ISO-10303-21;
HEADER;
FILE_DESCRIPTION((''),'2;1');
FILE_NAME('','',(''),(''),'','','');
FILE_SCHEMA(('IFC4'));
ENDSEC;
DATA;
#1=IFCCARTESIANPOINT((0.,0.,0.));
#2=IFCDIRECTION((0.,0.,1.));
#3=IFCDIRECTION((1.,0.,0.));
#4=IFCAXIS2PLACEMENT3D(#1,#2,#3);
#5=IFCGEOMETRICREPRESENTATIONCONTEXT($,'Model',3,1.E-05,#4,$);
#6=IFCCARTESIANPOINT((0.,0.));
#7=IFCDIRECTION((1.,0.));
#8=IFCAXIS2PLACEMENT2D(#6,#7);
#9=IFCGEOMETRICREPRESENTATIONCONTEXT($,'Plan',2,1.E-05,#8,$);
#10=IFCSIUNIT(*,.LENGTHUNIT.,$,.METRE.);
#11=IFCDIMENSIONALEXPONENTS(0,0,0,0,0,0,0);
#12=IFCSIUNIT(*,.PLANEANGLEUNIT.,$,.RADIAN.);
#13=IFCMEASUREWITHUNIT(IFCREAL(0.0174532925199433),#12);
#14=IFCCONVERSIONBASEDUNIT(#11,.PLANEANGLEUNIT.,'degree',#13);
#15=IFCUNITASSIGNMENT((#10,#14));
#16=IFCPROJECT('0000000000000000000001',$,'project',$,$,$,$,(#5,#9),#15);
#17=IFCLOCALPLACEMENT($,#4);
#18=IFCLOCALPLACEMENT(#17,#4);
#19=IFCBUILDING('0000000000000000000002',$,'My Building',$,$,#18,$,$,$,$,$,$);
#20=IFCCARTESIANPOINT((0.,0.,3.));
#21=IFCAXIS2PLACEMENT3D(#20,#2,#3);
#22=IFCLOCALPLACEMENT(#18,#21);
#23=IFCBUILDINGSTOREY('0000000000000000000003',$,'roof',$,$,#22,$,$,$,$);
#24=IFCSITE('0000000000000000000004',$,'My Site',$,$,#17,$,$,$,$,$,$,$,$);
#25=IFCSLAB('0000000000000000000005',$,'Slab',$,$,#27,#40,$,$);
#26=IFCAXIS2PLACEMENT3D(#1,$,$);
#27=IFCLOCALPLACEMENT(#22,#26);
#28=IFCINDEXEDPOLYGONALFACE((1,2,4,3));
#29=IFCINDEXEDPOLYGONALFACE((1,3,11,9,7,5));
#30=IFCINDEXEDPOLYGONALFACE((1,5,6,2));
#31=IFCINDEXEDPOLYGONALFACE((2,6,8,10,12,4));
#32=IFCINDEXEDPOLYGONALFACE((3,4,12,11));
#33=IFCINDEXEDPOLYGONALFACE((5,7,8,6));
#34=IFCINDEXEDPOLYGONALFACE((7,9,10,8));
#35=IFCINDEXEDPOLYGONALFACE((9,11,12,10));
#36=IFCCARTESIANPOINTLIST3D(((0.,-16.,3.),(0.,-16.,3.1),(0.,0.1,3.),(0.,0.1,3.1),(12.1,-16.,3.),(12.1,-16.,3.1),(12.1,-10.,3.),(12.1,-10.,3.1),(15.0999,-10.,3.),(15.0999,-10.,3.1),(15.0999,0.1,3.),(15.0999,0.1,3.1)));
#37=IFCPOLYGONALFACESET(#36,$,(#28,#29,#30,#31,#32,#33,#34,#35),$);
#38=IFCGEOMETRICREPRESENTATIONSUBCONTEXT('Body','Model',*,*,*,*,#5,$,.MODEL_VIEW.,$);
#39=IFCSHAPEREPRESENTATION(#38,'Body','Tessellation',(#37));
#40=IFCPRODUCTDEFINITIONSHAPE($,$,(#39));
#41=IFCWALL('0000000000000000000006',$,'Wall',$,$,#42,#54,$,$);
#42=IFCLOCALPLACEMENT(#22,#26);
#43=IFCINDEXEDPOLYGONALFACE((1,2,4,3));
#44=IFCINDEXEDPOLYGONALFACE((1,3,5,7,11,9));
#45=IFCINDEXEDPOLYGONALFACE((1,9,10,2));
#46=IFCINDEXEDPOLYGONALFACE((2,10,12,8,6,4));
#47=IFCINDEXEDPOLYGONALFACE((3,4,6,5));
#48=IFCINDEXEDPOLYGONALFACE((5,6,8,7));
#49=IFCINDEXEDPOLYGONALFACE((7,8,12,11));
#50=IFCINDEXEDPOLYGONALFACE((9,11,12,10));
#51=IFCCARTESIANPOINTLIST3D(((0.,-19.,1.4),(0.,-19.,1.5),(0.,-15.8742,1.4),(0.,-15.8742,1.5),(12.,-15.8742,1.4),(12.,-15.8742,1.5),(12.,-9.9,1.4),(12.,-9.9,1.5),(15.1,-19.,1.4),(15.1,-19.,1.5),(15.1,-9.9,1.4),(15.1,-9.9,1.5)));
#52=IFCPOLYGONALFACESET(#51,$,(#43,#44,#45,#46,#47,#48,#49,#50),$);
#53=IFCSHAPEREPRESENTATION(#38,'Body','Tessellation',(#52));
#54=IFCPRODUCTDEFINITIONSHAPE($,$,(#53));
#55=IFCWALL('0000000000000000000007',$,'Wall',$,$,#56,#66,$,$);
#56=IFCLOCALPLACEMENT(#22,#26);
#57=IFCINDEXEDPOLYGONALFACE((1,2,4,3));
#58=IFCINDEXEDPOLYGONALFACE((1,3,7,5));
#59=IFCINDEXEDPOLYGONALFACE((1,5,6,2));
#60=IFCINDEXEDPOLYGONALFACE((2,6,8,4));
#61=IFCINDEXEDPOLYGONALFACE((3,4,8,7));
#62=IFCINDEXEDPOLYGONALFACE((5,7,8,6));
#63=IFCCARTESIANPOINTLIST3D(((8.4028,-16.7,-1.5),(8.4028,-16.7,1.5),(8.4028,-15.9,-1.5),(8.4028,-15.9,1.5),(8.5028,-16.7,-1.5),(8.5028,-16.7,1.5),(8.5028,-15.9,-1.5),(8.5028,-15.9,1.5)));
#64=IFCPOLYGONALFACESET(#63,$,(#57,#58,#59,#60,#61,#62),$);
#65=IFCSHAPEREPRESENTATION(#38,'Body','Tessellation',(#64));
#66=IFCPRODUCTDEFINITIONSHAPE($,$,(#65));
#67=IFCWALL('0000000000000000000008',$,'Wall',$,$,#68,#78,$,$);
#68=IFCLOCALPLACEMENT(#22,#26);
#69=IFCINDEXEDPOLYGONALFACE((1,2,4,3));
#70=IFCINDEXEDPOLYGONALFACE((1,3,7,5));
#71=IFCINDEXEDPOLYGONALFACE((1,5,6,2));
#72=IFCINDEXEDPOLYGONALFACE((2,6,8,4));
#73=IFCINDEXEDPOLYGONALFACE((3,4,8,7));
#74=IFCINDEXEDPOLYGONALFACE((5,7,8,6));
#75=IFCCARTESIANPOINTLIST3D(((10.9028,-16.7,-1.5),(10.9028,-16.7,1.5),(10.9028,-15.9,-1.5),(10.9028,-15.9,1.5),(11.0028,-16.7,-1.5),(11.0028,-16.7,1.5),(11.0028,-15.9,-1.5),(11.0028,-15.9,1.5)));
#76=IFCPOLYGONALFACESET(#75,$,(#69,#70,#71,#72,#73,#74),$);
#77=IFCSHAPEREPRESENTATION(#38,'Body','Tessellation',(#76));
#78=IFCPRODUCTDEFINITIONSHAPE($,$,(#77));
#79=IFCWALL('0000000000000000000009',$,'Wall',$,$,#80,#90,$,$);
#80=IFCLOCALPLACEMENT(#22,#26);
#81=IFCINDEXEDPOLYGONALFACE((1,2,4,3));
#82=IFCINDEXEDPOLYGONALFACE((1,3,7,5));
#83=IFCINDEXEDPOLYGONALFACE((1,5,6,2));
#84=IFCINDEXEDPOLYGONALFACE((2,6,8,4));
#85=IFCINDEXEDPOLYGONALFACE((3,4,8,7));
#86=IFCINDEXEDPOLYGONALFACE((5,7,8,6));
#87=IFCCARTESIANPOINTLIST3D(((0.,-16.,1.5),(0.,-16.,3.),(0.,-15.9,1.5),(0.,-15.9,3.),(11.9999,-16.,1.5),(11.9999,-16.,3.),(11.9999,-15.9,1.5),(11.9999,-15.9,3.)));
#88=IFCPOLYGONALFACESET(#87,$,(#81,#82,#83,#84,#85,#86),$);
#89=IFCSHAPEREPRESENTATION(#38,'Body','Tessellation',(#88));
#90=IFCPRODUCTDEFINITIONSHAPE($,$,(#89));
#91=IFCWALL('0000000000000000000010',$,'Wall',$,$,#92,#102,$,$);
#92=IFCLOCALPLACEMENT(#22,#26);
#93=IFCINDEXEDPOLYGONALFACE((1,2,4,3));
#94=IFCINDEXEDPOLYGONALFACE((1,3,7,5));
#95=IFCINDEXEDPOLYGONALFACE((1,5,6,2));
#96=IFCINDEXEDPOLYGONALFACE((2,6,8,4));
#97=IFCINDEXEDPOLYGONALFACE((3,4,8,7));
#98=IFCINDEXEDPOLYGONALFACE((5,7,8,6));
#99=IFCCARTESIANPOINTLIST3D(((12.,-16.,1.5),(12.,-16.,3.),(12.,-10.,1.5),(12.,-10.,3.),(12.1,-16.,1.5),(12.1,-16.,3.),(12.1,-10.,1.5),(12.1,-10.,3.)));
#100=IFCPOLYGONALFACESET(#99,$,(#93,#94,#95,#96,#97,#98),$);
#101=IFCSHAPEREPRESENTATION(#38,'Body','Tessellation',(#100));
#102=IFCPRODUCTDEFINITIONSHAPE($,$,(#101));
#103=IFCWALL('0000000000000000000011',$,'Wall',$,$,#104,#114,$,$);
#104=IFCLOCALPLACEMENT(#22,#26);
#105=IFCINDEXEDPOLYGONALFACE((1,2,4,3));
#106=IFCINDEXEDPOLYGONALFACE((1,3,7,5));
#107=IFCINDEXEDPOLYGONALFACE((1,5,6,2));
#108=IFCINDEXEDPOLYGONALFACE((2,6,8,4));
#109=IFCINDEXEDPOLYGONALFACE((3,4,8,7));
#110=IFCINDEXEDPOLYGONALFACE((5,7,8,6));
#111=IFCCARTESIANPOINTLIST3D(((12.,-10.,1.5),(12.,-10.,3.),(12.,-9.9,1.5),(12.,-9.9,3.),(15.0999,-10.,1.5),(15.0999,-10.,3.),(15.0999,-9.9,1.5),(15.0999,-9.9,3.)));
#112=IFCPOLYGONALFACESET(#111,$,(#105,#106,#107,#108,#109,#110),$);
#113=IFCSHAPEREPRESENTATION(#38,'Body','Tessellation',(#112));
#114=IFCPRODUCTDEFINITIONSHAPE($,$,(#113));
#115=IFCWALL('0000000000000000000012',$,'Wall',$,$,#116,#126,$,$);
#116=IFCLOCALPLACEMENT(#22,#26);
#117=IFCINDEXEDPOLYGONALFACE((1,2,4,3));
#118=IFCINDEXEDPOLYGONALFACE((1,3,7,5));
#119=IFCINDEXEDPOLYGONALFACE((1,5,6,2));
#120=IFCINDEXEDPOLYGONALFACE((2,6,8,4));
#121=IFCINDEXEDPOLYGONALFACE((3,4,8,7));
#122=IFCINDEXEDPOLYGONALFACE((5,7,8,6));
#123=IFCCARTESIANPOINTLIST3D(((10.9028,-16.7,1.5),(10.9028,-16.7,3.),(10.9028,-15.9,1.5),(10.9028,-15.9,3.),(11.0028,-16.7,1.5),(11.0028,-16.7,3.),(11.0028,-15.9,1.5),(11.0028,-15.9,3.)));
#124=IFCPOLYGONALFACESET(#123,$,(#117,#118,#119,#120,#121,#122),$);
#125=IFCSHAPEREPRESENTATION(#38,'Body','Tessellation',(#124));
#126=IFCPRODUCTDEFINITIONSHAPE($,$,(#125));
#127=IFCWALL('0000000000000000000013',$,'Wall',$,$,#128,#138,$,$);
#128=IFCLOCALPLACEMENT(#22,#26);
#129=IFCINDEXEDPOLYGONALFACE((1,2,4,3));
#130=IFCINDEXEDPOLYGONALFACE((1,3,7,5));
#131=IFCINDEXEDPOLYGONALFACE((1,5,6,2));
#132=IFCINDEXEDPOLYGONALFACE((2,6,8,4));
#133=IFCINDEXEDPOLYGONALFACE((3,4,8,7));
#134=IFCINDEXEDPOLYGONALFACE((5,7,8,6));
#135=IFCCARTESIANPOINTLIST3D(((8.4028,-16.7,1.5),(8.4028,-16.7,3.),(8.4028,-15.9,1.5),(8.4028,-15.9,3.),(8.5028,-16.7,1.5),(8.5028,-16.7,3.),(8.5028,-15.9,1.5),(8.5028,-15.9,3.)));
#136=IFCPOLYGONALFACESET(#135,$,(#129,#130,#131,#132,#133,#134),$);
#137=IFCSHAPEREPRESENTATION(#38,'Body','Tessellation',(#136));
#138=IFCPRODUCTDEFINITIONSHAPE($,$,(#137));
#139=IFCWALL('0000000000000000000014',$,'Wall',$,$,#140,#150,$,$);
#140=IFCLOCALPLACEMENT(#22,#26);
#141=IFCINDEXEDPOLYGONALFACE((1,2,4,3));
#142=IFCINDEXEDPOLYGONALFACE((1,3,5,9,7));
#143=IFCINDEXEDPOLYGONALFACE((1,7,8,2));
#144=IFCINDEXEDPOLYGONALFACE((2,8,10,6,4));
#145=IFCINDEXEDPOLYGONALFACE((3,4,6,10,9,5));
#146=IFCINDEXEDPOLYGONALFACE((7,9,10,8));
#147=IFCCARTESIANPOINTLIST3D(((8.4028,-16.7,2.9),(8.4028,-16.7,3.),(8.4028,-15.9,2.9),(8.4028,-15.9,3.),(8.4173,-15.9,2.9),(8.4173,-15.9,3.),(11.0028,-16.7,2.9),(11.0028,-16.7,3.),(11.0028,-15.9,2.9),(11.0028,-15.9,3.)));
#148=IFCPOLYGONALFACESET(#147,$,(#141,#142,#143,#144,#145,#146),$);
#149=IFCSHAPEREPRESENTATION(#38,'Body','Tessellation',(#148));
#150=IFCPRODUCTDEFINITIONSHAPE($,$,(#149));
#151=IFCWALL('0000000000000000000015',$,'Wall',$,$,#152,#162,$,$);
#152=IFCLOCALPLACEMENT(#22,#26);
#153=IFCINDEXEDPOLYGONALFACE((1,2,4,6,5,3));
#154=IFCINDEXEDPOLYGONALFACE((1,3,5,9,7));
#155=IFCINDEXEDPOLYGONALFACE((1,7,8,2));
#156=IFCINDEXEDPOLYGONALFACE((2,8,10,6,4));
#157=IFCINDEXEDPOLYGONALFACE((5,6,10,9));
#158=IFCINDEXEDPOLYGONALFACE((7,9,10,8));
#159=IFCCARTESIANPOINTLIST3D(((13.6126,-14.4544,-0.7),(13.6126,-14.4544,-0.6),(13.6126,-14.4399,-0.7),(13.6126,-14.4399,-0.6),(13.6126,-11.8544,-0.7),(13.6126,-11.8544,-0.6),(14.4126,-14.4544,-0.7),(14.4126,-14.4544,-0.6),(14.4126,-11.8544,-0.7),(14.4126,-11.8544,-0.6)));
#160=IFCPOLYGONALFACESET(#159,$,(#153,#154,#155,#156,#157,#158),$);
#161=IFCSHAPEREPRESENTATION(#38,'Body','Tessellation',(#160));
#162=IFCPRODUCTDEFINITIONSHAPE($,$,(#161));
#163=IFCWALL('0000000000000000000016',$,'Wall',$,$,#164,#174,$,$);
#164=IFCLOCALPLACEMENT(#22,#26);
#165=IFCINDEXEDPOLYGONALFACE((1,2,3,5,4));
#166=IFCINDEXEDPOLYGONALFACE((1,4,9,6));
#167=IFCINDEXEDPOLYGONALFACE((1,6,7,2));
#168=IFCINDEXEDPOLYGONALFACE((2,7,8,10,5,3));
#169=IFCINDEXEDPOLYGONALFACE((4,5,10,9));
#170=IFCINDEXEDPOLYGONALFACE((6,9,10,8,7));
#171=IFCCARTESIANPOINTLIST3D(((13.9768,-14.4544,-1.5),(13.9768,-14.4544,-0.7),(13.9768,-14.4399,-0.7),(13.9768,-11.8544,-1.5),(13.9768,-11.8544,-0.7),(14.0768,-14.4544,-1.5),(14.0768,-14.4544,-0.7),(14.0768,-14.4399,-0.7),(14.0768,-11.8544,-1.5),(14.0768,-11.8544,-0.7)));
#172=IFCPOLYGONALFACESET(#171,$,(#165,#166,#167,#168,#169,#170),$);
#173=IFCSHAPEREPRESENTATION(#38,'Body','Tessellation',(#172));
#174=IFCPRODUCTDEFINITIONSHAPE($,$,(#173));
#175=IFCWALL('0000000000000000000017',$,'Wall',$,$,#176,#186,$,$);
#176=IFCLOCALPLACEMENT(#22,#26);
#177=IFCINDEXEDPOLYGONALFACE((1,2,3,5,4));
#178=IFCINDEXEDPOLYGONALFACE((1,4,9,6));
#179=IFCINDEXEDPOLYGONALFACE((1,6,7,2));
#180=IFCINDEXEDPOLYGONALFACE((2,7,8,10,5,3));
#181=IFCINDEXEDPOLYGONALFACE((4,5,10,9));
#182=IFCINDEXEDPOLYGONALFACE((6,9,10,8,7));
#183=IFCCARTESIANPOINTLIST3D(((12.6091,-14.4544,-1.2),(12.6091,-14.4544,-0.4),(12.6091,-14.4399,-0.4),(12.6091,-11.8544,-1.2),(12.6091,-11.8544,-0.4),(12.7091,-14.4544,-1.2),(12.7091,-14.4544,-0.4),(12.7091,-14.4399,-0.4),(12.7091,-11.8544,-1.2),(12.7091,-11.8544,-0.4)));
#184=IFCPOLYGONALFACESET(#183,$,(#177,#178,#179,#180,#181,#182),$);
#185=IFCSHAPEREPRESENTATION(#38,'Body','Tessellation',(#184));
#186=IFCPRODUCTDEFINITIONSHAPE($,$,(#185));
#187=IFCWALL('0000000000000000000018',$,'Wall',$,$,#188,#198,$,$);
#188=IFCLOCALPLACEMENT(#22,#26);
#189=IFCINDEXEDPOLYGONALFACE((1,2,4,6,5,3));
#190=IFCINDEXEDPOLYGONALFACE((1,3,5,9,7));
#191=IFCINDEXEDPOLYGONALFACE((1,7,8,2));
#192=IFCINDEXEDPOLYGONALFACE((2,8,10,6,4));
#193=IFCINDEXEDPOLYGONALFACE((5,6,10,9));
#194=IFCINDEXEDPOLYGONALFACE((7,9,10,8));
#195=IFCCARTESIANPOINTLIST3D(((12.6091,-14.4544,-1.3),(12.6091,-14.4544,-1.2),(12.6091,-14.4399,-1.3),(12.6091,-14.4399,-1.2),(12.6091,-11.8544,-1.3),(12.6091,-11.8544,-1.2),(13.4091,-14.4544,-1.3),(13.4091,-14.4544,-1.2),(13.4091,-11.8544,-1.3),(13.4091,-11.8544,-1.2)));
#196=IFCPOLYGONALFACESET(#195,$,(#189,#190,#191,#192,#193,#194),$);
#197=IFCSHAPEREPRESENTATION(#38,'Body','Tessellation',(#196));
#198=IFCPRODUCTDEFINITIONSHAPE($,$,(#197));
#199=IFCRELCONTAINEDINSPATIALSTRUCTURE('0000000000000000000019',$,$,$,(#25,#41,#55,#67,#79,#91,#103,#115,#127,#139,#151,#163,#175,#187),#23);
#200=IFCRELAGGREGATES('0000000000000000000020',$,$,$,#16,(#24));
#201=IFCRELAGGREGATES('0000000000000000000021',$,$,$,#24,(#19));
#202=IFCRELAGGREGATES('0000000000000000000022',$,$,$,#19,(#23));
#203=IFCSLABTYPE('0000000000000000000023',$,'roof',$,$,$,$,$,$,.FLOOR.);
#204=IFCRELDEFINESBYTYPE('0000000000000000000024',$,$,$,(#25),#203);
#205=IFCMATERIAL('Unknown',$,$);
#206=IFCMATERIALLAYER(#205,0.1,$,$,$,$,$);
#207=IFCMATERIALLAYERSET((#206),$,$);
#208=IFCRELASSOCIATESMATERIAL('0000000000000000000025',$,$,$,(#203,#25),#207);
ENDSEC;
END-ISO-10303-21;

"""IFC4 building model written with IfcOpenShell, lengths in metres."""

from ifc_helpers import new_model, entity, si_unit, converted_unit, frame, origin_with_axes, origin_2d_with_axis, place, context, subcontext, project, spatial, line, indexed_curve, outline, extrude, material, layer, layer_set, layer_usage, type_object, element, save


model = new_model("IFC4")

# Units and contexts
model_context = context("Model", 3, precision=1e-05, world=origin_with_axes())
plan_context = context("Plan", 2, precision=1e-05, world=origin_2d_with_axis())
body_context_1 = subcontext(model_context, "Body", "Model", "MODEL_VIEW")
ifc_project = project(units=[si_unit("LENGTHUNIT", "METRE"), converted_unit("PLANEANGLEUNIT", "degree", entity("IfcReal", 0.0174532925199433), si_unit("PLANEANGLEUNIT", "RADIAN"), dimensions=[0, 0, 0, 0, 0, 0, 0])], contexts=[model_context, plan_context])

# Site, building, storey
site_placement = place(None, origin_with_axes())
site = spatial("IfcSite", under=ifc_project, at=site_placement, Name="My Site")
building_placement = place(site_placement, origin_with_axes())
building = spatial("IfcBuilding", under=site, at=building_placement, Name="My Building")
storey_placement = place(building_placement, frame((0.0, 0.0, 3.0), z_axis=(0.0, 0.0, 1.0), x_axis=(1.0, 0.0, 0.0)))
storey = spatial("IfcBuildingStorey", under=building, at=storey_placement, Name="roof")

# Slab
ifc_material = material(Name="Unknown")
ifc_layer_1 = layer(ifc_material, 0.1)
ifc_layer_set_1 = layer_set([ifc_layer_1])
ifc_layer_usage_1 = layer_usage(ifc_layer_set_1, "AXIS3", "POSITIVE", -0.1)
slab_type = type_object("IfcSlabType", Name="roof", PredefinedType="FLOOR", material=ifc_layer_set_1)
slab_placement = place(storey_placement, frame((0.0, -16.0, 3.1), z_axis=(0.0, 0.0, 1.0), x_axis=(1.0, 0.0, 0.0)))
element("IfcSlab", 1, at=slab_placement, inside=storey, type_object=slab_type, material=ifc_layer_usage_1, Name="Slab", context=body_context_1, shape_type="SweptSolid", body=[
    extrude(outline(indexed_curve([(0.0, 0.0), (12.1, 0.0), (12.1, 6.0), (15.0999, 6.0), (15.0999, 16.1), (0.0, 16.1), (0.0, 0.0)])), frame((0.0, 0.0, -0.1), z_axis=(0.0, 0.0, 1.0), x_axis=(1.0, 0.0, 0.0)), (0.0, 0.0, 1.0), 0.1),
])

# Walls
wall_1_placement = place(storey_placement, frame((15.1, -9.9, 1.5), z_axis=(0.0, 0.0, 1.0), x_axis=(1.0, 0.0, 0.0)))
element("IfcWall", 2, at=wall_1_placement, inside=storey, Name="Wall", context=body_context_1, shape_type="SweptSolid", body=[
    extrude(outline(indexed_curve([(0.0, 0.0), (-3.1, 0.0), (-3.1, -5.9742), (-15.1, -5.9742), (-15.1, -9.1), (0.0, -9.1), (0.0, 0.0)])), frame((0.0, 0.0, -0.1), z_axis=(0.0, 0.0, 1.0), x_axis=(1.0, 0.0, 0.0)), (0.0, 0.0, 1.0), 0.1),
])
for number, where, z_axis, x_axis, name in (
    (3, (8.5028, -16.7, -1.5), (0.0, 0.0, 1.0), (0.0, 1.0, 0.0), "Wall"),
    (4, (11.0028, -16.7, -1.5), (0.0, 0.0, 1.0), (0.0, 1.0, 0.0), "Wall"),
):
    element("IfcWall", number, at=place(storey_placement, frame(where, z_axis=z_axis, x_axis=x_axis)), inside=storey, Name=name, context=body_context_1, shape_type="SweptSolid", body=[
        extrude(outline(indexed_curve([(0.0, 0.0), (0.0, 0.1), (0.8, 0.1), (0.8, 0.0)], segments=[line(1, 2, 3, 4, 1)])), origin_with_axes(), (0.0, 0.0, 1.0), 3.0),
    ])
wall_2_placement = place(storey_placement, frame((0.0, -16.0, 1.5), z_axis=(0.0, 0.0, 1.0), x_axis=(1.0, 0.0, 0.0)))
element("IfcWall", 5, at=wall_2_placement, inside=storey, Name="Wall", context=body_context_1, shape_type="SweptSolid", body=[
    extrude(outline(indexed_curve([(0.0, 0.0), (0.0, 0.1), (11.9999, 0.1), (11.9999, 0.0)], segments=[line(1, 2, 3, 4, 1)])), origin_with_axes(), (0.0, 0.0, 1.0), 1.5),
])
wall_3_placement = place(storey_placement, frame((12.1, -16.0, 1.5), z_axis=(0.0, 0.0, 1.0), x_axis=(0.0, 1.0, 0.0)))
element("IfcWall", 6, at=wall_3_placement, inside=storey, Name="Wall", context=body_context_1, shape_type="SweptSolid", body=[
    extrude(outline(indexed_curve([(0.0, 0.0), (0.0, 0.1), (6.0, 0.1), (6.0, 0.0)], segments=[line(1, 2, 3, 4, 1)])), origin_with_axes(), (0.0, 0.0, 1.0), 1.5),
])
wall_4_placement = place(storey_placement, frame((12.0, -10.0, 1.5), z_axis=(0.0, 0.0, 1.0), x_axis=(1.0, 0.0, 0.0)))
element("IfcWall", 7, at=wall_4_placement, inside=storey, Name="Wall", context=body_context_1, shape_type="SweptSolid", body=[
    extrude(outline(indexed_curve([(0.0, 0.0), (0.0, 0.1), (3.0999, 0.1), (3.0999, 0.0)], segments=[line(1, 2, 3, 4, 1)])), origin_with_axes(), (0.0, 0.0, 1.0), 1.5),
])
for number, where, z_axis, x_axis, name in (
    (8, (11.0028, -16.7, 1.5), (0.0, 0.0, 1.0), (0.0, 1.0, 0.0), "Wall"),
    (9, (8.5028, -16.7, 1.5), (0.0, 0.0, 1.0), (0.0, 1.0, 0.0), "Wall"),
):
    element("IfcWall", number, at=place(storey_placement, frame(where, z_axis=z_axis, x_axis=x_axis)), inside=storey, Name=name, context=body_context_1, shape_type="SweptSolid", body=[
        extrude(outline(indexed_curve([(0.0, 0.0), (0.0, 0.1), (0.8, 0.1), (0.8, 0.0)], segments=[line(1, 2, 3, 4, 1)])), origin_with_axes(), (0.0, 0.0, 1.0), 1.5),
    ])
for number, where, z_axis, x_axis, name in (
    (10, (8.4028, -16.7, 3.0), (0.0, 0.0, 1.0), (1.0, 0.0, 0.0), "Wall"),
    (11, (14.4126, -14.4544, -0.6), (0.0, 0.0, 1.0), (0.0, 1.0, 0.0), "Wall"),
    (12, (14.0768, -14.4544, -1.5), (1.0, 0.0, 0.0), (0.0, 1.0, 0.0), "Wall"),
    (13, (12.7091, -14.4544, -1.2), (1.0, 0.0, 0.0), (0.0, 1.0, 0.0), "Wall"),
    (14, (13.4091, -14.4544, -1.2), (0.0, 0.0, 1.0), (0.0, 1.0, 0.0), "Wall"),
):
    element("IfcWall", number, at=place(storey_placement, frame(where, z_axis=z_axis, x_axis=x_axis)), inside=storey, Name=name, context=body_context_1, shape_type="SweptSolid", body=[
        extrude(outline(indexed_curve([(0.0, 0.0), (2.6, 0.0), (2.6, 0.8), (0.0145, 0.8), (0.0, 0.8), (0.0, 0.0)])), frame((0.0, 0.0, -0.1), z_axis=(0.0, 0.0, 1.0), x_axis=(1.0, 0.0, 0.0)), (0.0, 0.0, 1.0), 0.1),
    ])

save(model, "model.ifc")
